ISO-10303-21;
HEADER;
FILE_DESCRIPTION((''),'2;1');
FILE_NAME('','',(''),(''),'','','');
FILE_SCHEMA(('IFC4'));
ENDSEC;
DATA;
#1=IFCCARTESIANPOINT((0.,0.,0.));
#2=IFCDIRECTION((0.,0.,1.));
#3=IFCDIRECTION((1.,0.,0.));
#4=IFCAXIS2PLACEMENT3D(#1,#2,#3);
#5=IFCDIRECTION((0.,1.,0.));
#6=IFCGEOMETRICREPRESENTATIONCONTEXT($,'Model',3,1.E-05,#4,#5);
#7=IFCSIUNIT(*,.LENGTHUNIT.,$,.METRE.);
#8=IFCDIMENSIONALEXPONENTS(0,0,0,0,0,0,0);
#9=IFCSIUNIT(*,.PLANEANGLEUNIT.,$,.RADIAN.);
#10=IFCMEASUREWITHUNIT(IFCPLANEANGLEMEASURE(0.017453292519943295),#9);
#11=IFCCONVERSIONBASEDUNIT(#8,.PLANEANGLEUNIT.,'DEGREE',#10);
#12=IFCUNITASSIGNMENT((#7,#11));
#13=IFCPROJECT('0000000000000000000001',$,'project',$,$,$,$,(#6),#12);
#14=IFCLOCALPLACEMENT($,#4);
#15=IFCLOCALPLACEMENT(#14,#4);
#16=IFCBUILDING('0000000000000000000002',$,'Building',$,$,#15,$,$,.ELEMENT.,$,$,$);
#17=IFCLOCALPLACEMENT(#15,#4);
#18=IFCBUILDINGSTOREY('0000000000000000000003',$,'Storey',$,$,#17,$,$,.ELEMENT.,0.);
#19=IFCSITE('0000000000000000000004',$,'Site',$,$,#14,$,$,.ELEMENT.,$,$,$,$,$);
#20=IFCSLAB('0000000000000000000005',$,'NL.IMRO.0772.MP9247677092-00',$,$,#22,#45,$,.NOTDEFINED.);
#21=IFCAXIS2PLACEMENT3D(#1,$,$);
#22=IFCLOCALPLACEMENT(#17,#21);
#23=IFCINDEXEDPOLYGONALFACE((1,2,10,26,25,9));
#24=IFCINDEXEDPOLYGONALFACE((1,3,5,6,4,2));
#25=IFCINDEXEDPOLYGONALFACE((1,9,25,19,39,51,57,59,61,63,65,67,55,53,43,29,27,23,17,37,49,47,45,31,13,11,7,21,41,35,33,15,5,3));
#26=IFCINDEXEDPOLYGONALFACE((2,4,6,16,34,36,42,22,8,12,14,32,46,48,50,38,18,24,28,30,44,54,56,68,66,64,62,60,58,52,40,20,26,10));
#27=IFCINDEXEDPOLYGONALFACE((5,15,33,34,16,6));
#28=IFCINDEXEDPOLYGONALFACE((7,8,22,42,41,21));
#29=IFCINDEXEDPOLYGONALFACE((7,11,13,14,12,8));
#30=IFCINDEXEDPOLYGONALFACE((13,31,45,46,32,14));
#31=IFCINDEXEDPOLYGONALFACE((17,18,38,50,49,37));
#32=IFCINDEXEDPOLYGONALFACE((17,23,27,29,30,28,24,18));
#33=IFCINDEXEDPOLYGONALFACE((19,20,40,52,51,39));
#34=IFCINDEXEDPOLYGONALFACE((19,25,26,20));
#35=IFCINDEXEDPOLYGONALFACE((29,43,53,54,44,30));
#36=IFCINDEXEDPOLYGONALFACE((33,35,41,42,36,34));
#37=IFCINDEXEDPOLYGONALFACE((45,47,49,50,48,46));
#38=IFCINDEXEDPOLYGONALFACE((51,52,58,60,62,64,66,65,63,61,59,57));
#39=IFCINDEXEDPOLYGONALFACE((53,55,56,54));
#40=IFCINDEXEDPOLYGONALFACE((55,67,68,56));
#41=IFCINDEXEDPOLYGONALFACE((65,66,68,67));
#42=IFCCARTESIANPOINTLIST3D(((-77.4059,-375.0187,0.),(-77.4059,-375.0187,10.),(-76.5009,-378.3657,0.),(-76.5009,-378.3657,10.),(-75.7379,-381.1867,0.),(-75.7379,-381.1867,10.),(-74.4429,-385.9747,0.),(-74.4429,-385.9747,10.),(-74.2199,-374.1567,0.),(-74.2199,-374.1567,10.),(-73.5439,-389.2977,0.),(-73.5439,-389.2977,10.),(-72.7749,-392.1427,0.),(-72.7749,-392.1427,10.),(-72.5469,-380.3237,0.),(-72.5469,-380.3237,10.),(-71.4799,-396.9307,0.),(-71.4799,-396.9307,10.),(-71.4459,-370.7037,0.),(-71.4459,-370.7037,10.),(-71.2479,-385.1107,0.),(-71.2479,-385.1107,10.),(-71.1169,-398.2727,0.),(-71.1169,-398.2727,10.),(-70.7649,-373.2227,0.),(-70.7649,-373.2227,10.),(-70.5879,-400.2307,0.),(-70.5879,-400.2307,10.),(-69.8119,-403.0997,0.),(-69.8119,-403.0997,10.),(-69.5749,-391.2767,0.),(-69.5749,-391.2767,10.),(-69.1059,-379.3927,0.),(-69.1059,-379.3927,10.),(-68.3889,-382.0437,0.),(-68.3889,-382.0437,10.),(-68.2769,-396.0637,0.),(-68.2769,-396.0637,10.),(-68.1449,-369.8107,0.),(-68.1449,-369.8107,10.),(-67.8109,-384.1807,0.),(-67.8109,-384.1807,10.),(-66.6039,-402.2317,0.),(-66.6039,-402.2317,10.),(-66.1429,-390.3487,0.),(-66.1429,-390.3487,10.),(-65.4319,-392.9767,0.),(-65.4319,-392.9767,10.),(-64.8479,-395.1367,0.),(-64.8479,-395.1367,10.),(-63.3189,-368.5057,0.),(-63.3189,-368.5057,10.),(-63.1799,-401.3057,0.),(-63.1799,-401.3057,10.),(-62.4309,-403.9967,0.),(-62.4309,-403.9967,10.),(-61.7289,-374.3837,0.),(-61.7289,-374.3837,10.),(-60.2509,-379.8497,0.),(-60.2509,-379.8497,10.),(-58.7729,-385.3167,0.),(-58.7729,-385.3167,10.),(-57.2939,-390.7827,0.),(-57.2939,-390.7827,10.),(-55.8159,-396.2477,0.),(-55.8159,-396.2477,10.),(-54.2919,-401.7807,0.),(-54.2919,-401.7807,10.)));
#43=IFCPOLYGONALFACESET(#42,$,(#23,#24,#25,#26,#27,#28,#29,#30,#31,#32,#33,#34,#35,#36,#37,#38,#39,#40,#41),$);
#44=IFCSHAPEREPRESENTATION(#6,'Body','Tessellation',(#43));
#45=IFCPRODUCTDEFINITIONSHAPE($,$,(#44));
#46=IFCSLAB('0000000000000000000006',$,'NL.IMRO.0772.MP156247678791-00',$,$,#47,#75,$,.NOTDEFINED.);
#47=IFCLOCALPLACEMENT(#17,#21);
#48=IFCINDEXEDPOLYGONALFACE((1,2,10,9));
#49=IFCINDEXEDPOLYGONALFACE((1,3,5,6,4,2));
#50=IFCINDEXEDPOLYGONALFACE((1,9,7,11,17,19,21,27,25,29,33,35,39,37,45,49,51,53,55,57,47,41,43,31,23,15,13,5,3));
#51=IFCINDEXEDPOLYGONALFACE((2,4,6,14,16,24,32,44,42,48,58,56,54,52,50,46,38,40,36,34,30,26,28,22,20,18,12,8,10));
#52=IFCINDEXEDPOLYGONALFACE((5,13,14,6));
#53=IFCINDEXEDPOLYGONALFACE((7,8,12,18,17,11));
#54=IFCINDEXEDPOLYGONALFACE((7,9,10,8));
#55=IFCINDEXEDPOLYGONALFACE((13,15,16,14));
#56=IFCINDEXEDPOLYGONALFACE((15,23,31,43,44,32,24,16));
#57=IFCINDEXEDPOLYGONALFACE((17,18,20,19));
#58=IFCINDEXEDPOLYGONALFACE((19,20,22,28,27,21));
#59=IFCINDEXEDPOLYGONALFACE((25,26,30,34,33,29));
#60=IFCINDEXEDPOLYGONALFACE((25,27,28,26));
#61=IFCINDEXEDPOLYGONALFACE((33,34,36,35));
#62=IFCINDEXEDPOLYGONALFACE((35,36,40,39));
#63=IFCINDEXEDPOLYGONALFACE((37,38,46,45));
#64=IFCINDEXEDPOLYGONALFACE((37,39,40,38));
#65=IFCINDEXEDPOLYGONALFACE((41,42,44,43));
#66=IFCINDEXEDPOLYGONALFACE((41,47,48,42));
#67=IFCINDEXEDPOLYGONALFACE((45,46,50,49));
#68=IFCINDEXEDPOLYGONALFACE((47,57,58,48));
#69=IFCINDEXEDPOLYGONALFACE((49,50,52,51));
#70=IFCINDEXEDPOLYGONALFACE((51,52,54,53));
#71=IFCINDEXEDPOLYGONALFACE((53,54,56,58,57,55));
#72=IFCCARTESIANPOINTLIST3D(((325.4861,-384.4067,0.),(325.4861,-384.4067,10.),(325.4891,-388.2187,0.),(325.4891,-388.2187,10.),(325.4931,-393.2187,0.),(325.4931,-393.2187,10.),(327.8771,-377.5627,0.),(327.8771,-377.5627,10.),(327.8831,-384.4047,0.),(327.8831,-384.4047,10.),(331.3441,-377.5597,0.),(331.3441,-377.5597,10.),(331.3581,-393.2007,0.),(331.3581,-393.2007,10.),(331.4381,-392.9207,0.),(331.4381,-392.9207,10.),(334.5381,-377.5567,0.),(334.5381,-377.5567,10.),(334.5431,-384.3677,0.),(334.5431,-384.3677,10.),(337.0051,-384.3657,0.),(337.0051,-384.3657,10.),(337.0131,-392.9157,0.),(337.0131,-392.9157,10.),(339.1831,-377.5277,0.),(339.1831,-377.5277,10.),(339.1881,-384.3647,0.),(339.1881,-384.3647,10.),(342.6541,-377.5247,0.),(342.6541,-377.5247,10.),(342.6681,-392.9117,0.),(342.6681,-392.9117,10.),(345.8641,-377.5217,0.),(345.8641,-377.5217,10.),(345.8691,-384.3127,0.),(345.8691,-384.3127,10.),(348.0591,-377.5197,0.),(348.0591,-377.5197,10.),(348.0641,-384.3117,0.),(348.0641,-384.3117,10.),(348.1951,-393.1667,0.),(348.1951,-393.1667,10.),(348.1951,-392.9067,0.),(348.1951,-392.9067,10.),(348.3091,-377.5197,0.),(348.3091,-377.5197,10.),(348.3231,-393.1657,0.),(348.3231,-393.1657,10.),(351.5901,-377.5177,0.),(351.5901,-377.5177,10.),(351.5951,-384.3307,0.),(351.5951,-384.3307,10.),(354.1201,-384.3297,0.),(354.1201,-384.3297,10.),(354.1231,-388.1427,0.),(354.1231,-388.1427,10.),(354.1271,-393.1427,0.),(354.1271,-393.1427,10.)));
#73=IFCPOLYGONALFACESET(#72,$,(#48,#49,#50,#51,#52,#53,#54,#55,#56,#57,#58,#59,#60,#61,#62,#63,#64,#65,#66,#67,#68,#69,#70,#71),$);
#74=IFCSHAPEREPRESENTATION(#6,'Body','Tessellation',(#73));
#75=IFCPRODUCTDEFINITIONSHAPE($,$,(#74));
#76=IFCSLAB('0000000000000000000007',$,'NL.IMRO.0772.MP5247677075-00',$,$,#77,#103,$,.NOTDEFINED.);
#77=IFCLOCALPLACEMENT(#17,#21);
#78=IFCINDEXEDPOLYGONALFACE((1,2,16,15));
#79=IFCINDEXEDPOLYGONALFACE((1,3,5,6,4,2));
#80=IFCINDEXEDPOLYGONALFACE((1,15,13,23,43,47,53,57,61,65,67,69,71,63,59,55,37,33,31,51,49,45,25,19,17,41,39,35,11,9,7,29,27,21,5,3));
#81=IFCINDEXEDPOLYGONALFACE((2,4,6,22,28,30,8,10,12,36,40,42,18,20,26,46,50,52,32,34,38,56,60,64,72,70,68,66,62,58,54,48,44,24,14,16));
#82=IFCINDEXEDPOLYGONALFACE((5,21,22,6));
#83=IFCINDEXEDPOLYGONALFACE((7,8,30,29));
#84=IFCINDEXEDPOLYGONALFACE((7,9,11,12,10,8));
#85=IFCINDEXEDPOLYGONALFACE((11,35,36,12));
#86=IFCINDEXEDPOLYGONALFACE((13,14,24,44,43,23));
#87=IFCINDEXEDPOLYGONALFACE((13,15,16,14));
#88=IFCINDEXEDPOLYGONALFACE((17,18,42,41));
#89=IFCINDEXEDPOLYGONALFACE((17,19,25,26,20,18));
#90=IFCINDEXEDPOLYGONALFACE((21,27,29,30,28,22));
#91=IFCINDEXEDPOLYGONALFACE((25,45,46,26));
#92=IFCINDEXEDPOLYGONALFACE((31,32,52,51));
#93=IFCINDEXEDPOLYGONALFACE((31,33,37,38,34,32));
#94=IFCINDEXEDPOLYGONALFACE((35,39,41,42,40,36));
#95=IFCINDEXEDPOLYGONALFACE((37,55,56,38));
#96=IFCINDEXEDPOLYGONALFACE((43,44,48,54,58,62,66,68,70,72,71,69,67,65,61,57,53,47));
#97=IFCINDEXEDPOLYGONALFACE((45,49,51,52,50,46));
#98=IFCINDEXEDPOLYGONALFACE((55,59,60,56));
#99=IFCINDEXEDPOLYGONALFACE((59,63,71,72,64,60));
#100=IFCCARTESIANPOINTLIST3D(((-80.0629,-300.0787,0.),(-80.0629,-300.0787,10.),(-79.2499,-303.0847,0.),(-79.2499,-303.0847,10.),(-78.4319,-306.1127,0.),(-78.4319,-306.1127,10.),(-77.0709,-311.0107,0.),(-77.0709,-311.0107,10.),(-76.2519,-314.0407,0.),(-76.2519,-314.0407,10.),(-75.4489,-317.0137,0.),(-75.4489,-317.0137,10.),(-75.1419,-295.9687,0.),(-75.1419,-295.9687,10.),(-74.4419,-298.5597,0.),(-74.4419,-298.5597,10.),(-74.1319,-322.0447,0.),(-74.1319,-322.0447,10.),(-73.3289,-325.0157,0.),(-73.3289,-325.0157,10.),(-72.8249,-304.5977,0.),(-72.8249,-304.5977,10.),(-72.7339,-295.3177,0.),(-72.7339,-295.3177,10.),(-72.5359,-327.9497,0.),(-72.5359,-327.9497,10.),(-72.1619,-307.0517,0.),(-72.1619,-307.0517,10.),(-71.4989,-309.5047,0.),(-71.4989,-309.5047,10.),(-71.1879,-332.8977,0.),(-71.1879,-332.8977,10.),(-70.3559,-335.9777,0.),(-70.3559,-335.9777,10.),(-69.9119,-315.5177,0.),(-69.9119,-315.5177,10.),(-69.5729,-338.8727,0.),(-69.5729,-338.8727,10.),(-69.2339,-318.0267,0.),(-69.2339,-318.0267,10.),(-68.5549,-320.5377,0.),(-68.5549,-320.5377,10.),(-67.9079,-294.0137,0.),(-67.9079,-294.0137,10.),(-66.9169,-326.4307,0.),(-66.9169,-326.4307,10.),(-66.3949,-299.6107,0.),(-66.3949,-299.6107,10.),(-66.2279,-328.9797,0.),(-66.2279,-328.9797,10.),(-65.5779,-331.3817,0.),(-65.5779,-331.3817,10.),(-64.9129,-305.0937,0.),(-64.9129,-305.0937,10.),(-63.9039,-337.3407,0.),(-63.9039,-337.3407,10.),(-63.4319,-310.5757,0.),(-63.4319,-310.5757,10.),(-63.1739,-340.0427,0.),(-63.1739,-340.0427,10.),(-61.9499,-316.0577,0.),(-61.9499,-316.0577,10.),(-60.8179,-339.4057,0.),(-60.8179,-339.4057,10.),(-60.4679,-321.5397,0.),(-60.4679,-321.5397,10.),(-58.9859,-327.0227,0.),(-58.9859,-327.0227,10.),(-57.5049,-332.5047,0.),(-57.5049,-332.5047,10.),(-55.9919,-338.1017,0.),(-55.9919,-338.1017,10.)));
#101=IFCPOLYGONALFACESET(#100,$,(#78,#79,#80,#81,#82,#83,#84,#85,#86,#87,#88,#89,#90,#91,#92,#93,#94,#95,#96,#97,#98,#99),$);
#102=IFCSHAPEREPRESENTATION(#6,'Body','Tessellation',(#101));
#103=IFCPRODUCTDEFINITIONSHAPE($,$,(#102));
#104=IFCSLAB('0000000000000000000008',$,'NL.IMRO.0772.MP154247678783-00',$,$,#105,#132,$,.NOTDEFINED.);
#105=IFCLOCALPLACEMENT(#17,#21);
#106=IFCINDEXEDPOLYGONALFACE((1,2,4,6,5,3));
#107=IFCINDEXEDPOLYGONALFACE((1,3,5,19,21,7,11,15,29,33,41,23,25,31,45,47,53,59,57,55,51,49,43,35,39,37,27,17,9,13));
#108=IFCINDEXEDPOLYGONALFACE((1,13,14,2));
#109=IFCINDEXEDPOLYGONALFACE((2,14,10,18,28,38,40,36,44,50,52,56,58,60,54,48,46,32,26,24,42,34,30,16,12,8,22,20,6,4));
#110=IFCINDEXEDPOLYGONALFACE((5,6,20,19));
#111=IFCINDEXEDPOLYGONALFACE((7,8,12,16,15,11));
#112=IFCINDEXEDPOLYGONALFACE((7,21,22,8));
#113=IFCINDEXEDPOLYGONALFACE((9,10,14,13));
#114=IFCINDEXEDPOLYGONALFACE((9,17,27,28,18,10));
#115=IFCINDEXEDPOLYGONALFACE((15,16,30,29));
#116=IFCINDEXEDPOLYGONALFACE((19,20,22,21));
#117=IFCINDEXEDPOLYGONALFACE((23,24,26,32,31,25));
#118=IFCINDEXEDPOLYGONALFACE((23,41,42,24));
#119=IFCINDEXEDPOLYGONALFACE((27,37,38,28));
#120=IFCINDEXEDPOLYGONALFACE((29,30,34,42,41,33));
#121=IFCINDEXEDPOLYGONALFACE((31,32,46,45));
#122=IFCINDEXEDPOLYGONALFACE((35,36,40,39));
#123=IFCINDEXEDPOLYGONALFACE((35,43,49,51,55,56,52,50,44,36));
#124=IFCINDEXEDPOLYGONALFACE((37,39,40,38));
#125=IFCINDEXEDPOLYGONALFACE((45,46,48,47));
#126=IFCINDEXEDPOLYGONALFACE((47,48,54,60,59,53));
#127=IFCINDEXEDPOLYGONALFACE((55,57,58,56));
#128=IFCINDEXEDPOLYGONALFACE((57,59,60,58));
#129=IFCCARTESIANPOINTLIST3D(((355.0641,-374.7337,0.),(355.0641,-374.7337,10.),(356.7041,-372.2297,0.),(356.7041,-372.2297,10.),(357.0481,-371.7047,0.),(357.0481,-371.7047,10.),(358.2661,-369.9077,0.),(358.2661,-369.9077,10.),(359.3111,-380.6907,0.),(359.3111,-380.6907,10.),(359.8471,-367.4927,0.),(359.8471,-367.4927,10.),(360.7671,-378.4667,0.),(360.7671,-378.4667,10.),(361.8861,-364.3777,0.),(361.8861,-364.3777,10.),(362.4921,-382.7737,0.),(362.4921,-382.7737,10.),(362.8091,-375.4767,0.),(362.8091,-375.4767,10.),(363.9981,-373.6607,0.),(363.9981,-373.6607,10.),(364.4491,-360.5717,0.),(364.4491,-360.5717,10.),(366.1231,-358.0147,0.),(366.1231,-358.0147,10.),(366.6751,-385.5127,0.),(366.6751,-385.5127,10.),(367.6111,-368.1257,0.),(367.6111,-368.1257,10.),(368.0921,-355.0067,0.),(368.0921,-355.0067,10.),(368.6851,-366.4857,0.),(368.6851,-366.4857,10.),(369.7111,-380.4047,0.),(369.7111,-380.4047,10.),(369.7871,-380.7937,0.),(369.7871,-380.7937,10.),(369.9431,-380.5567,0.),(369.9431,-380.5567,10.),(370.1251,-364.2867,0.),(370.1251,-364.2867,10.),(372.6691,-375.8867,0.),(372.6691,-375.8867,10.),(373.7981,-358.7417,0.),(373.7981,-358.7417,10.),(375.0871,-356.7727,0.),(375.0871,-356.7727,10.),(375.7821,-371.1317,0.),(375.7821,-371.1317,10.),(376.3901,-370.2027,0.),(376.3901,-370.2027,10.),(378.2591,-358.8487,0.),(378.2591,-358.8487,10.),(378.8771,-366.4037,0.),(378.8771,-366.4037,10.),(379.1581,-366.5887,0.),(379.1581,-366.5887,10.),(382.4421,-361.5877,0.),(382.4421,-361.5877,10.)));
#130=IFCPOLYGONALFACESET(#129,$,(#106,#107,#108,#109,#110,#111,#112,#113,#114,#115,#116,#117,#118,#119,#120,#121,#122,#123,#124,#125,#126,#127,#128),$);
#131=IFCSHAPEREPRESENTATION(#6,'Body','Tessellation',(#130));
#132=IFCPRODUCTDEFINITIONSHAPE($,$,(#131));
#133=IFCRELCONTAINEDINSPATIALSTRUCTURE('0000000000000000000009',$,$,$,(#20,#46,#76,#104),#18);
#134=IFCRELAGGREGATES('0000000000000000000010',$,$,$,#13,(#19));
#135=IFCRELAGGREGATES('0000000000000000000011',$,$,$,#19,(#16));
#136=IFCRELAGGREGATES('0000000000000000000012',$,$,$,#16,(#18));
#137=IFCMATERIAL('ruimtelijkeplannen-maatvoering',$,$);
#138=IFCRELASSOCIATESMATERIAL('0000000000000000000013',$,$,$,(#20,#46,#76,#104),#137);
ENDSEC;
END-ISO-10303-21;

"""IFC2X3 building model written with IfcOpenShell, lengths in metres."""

from ifc_helpers import new_model, entity, si_unit, converted_unit, direction, origin_with_axes, place, context, project, spatial, polyline, outline, extrude, material, element, save


model = new_model("IFC2X3")

# Units and contexts
model_context = context("Model", 3, precision=1e-05, world=origin_with_axes(), true_north=direction((0.0, 1.0, 0.0)))
ifc_project = project(units=[si_unit("LENGTHUNIT", "METRE"), converted_unit("PLANEANGLEUNIT", "DEGREE", entity("IfcPlaneAngleMeasure", 0.017453292519943295), si_unit("PLANEANGLEUNIT", "RADIAN"), dimensions=[0, 0, 0, 0, 0, 0, 0])], contexts=[model_context])

# Site, building, storey
site_placement = place(None, origin_with_axes())
site = spatial("IfcSite", under=ifc_project, at=site_placement, Name="Site", CompositionType="ELEMENT")
building_placement = place(site_placement, origin_with_axes())
building = spatial("IfcBuilding", under=site, at=building_placement, Name="Building", CompositionType="ELEMENT")
storey_placement = place(building_placement, origin_with_axes())
storey = spatial("IfcBuildingStorey", under=building, at=storey_placement, Name="Storey", CompositionType="ELEMENT", Elevation=0.0)

# Slabs
ifc_material = material(Name="ruimtelijkeplannen-maatvoering")
slab_1_placement = place(storey_placement, origin_with_axes())
element("IfcSlab", 1, at=slab_1_placement, inside=storey, material=ifc_material, Name="NL.IMRO.0772.MP9247677092-00", PredefinedType="NOTDEFINED", context=model_context, shape_type="SweptSolid", body=[
    extrude(outline(polyline([(-66.6039, -402.2317), (-69.8119, -403.0997), (-70.5879, -400.2307), (-71.1169, -398.2727), (-71.4799, -396.9307), (-68.2769, -396.0637), (-64.8479, -395.1367), (-65.4319, -392.9767), (-66.1429, -390.3487), (-69.5749, -391.2767), (-72.7749, -392.1427), (-73.5439, -389.2977), (-74.4429, -385.9747), (-71.2479, -385.1107), (-67.8109, -384.1807), (-68.3889, -382.0437), (-69.1059, -379.3927), (-72.5469, -380.3237), (-75.7379, -381.1867), (-76.5009, -378.3657), (-77.4059, -375.0187), (-74.2199, -374.1567), (-70.7649, -373.2227), (-71.4459, -370.7037), (-68.1449, -369.8107), (-63.3189, -368.5057), (-61.7289, -374.3837), (-60.2509, -379.8497), (-58.7729, -385.3167), (-57.2939, -390.7827), (-55.8159, -396.2477), (-54.2919, -401.7807), (-62.4309, -403.9967), (-63.1799, -401.3057), (-66.6039, -402.2317)])), origin_with_axes(), (0.0, 0.0, 1.0), 10.0),
])
slab_2_placement = place(storey_placement, origin_with_axes())
element("IfcSlab", 2, at=slab_2_placement, inside=storey, material=ifc_material, Name="NL.IMRO.0772.MP156247678791-00", PredefinedType="NOTDEFINED", context=model_context, shape_type="SweptSolid", body=[
    extrude(outline(polyline([(348.3231, -393.1657), (348.1951, -393.1667), (348.1951, -392.9067), (342.6681, -392.9117), (337.0131, -392.9157), (331.4381, -392.9207), (331.3581, -393.2007), (325.4931, -393.2187), (325.4891, -388.2187), (325.4861, -384.4067), (327.8831, -384.4047), (327.8771, -377.5627), (331.3441, -377.5597), (334.5381, -377.5567), (334.5431, -384.3677), (337.0051, -384.3657), (339.1881, -384.3647), (339.1831, -377.5277), (342.6541, -377.5247), (345.8641, -377.5217), (345.8691, -384.3127), (348.0641, -384.3117), (348.0591, -377.5197), (348.3091, -377.5197), (351.5901, -377.5177), (351.5951, -384.3307), (354.1201, -384.3297), (354.1231, -388.1427), (354.1271, -393.1427), (348.3231, -393.1657)])), origin_with_axes(), (0.0, 0.0, 1.0), 10.0),
])
slab_3_placement = place(storey_placement, origin_with_axes())
element("IfcSlab", 3, at=slab_3_placement, inside=storey, material=ifc_material, Name="NL.IMRO.0772.MP5247677075-00", PredefinedType="NOTDEFINED", context=model_context, shape_type="SweptSolid", body=[
    extrude(outline(polyline([(-80.0629, -300.0787), (-74.4419, -298.5597), (-75.1419, -295.9687), (-72.7339, -295.3177), (-67.9079, -294.0137), (-66.3949, -299.6107), (-64.9129, -305.0937), (-63.4319, -310.5757), (-61.9499, -316.0577), (-60.4679, -321.5397), (-58.9859, -327.0227), (-57.5049, -332.5047), (-55.9919, -338.1017), (-60.8179, -339.4057), (-63.1739, -340.0427), (-63.9039, -337.3407), (-69.5729, -338.8727), (-70.3559, -335.9777), (-71.1879, -332.8977), (-65.5779, -331.3817), (-66.2279, -328.9797), (-66.9169, -326.4307), (-72.5359, -327.9497), (-73.3289, -325.0157), (-74.1319, -322.0447), (-68.5549, -320.5377), (-69.2339, -318.0267), (-69.9119, -315.5177), (-75.4489, -317.0137), (-76.2519, -314.0407), (-77.0709, -311.0107), (-71.4989, -309.5047), (-72.1619, -307.0517), (-72.8249, -304.5977), (-78.4319, -306.1127), (-79.2499, -303.0847), (-80.0629, -300.0787)])), origin_with_axes(), (0.0, 0.0, 1.0), 10.0),
])
slab_4_placement = place(storey_placement, origin_with_axes())
element("IfcSlab", 4, at=slab_4_placement, inside=storey, material=ifc_material, Name="NL.IMRO.0772.MP154247678783-00", PredefinedType="NOTDEFINED", context=model_context, shape_type="SweptSolid", body=[
    extrude(outline(polyline([(369.9431, -380.5567), (369.7871, -380.7937), (366.6751, -385.5127), (362.4921, -382.7737), (359.3111, -380.6907), (360.7671, -378.4667), (355.0641, -374.7337), (356.7041, -372.2297), (357.0481, -371.7047), (362.8091, -375.4767), (363.9981, -373.6607), (358.2661, -369.9077), (359.8471, -367.4927), (361.8861, -364.3777), (367.6111, -368.1257), (368.6851, -366.4857), (370.1251, -364.2867), (364.4491, -360.5717), (366.1231, -358.0147), (368.0921, -355.0067), (373.7981, -358.7417), (375.0871, -356.7727), (378.2591, -358.8487), (382.4421, -361.5877), (379.1581, -366.5887), (378.8771, -366.4037), (376.3901, -370.2027), (375.7821, -371.1317), (372.6691, -375.8867), (369.7111, -380.4047), (369.9431, -380.5567)])), origin_with_axes(), (0.0, 0.0, 1.0), 10.0),
])

save(model, "model.ifc")
